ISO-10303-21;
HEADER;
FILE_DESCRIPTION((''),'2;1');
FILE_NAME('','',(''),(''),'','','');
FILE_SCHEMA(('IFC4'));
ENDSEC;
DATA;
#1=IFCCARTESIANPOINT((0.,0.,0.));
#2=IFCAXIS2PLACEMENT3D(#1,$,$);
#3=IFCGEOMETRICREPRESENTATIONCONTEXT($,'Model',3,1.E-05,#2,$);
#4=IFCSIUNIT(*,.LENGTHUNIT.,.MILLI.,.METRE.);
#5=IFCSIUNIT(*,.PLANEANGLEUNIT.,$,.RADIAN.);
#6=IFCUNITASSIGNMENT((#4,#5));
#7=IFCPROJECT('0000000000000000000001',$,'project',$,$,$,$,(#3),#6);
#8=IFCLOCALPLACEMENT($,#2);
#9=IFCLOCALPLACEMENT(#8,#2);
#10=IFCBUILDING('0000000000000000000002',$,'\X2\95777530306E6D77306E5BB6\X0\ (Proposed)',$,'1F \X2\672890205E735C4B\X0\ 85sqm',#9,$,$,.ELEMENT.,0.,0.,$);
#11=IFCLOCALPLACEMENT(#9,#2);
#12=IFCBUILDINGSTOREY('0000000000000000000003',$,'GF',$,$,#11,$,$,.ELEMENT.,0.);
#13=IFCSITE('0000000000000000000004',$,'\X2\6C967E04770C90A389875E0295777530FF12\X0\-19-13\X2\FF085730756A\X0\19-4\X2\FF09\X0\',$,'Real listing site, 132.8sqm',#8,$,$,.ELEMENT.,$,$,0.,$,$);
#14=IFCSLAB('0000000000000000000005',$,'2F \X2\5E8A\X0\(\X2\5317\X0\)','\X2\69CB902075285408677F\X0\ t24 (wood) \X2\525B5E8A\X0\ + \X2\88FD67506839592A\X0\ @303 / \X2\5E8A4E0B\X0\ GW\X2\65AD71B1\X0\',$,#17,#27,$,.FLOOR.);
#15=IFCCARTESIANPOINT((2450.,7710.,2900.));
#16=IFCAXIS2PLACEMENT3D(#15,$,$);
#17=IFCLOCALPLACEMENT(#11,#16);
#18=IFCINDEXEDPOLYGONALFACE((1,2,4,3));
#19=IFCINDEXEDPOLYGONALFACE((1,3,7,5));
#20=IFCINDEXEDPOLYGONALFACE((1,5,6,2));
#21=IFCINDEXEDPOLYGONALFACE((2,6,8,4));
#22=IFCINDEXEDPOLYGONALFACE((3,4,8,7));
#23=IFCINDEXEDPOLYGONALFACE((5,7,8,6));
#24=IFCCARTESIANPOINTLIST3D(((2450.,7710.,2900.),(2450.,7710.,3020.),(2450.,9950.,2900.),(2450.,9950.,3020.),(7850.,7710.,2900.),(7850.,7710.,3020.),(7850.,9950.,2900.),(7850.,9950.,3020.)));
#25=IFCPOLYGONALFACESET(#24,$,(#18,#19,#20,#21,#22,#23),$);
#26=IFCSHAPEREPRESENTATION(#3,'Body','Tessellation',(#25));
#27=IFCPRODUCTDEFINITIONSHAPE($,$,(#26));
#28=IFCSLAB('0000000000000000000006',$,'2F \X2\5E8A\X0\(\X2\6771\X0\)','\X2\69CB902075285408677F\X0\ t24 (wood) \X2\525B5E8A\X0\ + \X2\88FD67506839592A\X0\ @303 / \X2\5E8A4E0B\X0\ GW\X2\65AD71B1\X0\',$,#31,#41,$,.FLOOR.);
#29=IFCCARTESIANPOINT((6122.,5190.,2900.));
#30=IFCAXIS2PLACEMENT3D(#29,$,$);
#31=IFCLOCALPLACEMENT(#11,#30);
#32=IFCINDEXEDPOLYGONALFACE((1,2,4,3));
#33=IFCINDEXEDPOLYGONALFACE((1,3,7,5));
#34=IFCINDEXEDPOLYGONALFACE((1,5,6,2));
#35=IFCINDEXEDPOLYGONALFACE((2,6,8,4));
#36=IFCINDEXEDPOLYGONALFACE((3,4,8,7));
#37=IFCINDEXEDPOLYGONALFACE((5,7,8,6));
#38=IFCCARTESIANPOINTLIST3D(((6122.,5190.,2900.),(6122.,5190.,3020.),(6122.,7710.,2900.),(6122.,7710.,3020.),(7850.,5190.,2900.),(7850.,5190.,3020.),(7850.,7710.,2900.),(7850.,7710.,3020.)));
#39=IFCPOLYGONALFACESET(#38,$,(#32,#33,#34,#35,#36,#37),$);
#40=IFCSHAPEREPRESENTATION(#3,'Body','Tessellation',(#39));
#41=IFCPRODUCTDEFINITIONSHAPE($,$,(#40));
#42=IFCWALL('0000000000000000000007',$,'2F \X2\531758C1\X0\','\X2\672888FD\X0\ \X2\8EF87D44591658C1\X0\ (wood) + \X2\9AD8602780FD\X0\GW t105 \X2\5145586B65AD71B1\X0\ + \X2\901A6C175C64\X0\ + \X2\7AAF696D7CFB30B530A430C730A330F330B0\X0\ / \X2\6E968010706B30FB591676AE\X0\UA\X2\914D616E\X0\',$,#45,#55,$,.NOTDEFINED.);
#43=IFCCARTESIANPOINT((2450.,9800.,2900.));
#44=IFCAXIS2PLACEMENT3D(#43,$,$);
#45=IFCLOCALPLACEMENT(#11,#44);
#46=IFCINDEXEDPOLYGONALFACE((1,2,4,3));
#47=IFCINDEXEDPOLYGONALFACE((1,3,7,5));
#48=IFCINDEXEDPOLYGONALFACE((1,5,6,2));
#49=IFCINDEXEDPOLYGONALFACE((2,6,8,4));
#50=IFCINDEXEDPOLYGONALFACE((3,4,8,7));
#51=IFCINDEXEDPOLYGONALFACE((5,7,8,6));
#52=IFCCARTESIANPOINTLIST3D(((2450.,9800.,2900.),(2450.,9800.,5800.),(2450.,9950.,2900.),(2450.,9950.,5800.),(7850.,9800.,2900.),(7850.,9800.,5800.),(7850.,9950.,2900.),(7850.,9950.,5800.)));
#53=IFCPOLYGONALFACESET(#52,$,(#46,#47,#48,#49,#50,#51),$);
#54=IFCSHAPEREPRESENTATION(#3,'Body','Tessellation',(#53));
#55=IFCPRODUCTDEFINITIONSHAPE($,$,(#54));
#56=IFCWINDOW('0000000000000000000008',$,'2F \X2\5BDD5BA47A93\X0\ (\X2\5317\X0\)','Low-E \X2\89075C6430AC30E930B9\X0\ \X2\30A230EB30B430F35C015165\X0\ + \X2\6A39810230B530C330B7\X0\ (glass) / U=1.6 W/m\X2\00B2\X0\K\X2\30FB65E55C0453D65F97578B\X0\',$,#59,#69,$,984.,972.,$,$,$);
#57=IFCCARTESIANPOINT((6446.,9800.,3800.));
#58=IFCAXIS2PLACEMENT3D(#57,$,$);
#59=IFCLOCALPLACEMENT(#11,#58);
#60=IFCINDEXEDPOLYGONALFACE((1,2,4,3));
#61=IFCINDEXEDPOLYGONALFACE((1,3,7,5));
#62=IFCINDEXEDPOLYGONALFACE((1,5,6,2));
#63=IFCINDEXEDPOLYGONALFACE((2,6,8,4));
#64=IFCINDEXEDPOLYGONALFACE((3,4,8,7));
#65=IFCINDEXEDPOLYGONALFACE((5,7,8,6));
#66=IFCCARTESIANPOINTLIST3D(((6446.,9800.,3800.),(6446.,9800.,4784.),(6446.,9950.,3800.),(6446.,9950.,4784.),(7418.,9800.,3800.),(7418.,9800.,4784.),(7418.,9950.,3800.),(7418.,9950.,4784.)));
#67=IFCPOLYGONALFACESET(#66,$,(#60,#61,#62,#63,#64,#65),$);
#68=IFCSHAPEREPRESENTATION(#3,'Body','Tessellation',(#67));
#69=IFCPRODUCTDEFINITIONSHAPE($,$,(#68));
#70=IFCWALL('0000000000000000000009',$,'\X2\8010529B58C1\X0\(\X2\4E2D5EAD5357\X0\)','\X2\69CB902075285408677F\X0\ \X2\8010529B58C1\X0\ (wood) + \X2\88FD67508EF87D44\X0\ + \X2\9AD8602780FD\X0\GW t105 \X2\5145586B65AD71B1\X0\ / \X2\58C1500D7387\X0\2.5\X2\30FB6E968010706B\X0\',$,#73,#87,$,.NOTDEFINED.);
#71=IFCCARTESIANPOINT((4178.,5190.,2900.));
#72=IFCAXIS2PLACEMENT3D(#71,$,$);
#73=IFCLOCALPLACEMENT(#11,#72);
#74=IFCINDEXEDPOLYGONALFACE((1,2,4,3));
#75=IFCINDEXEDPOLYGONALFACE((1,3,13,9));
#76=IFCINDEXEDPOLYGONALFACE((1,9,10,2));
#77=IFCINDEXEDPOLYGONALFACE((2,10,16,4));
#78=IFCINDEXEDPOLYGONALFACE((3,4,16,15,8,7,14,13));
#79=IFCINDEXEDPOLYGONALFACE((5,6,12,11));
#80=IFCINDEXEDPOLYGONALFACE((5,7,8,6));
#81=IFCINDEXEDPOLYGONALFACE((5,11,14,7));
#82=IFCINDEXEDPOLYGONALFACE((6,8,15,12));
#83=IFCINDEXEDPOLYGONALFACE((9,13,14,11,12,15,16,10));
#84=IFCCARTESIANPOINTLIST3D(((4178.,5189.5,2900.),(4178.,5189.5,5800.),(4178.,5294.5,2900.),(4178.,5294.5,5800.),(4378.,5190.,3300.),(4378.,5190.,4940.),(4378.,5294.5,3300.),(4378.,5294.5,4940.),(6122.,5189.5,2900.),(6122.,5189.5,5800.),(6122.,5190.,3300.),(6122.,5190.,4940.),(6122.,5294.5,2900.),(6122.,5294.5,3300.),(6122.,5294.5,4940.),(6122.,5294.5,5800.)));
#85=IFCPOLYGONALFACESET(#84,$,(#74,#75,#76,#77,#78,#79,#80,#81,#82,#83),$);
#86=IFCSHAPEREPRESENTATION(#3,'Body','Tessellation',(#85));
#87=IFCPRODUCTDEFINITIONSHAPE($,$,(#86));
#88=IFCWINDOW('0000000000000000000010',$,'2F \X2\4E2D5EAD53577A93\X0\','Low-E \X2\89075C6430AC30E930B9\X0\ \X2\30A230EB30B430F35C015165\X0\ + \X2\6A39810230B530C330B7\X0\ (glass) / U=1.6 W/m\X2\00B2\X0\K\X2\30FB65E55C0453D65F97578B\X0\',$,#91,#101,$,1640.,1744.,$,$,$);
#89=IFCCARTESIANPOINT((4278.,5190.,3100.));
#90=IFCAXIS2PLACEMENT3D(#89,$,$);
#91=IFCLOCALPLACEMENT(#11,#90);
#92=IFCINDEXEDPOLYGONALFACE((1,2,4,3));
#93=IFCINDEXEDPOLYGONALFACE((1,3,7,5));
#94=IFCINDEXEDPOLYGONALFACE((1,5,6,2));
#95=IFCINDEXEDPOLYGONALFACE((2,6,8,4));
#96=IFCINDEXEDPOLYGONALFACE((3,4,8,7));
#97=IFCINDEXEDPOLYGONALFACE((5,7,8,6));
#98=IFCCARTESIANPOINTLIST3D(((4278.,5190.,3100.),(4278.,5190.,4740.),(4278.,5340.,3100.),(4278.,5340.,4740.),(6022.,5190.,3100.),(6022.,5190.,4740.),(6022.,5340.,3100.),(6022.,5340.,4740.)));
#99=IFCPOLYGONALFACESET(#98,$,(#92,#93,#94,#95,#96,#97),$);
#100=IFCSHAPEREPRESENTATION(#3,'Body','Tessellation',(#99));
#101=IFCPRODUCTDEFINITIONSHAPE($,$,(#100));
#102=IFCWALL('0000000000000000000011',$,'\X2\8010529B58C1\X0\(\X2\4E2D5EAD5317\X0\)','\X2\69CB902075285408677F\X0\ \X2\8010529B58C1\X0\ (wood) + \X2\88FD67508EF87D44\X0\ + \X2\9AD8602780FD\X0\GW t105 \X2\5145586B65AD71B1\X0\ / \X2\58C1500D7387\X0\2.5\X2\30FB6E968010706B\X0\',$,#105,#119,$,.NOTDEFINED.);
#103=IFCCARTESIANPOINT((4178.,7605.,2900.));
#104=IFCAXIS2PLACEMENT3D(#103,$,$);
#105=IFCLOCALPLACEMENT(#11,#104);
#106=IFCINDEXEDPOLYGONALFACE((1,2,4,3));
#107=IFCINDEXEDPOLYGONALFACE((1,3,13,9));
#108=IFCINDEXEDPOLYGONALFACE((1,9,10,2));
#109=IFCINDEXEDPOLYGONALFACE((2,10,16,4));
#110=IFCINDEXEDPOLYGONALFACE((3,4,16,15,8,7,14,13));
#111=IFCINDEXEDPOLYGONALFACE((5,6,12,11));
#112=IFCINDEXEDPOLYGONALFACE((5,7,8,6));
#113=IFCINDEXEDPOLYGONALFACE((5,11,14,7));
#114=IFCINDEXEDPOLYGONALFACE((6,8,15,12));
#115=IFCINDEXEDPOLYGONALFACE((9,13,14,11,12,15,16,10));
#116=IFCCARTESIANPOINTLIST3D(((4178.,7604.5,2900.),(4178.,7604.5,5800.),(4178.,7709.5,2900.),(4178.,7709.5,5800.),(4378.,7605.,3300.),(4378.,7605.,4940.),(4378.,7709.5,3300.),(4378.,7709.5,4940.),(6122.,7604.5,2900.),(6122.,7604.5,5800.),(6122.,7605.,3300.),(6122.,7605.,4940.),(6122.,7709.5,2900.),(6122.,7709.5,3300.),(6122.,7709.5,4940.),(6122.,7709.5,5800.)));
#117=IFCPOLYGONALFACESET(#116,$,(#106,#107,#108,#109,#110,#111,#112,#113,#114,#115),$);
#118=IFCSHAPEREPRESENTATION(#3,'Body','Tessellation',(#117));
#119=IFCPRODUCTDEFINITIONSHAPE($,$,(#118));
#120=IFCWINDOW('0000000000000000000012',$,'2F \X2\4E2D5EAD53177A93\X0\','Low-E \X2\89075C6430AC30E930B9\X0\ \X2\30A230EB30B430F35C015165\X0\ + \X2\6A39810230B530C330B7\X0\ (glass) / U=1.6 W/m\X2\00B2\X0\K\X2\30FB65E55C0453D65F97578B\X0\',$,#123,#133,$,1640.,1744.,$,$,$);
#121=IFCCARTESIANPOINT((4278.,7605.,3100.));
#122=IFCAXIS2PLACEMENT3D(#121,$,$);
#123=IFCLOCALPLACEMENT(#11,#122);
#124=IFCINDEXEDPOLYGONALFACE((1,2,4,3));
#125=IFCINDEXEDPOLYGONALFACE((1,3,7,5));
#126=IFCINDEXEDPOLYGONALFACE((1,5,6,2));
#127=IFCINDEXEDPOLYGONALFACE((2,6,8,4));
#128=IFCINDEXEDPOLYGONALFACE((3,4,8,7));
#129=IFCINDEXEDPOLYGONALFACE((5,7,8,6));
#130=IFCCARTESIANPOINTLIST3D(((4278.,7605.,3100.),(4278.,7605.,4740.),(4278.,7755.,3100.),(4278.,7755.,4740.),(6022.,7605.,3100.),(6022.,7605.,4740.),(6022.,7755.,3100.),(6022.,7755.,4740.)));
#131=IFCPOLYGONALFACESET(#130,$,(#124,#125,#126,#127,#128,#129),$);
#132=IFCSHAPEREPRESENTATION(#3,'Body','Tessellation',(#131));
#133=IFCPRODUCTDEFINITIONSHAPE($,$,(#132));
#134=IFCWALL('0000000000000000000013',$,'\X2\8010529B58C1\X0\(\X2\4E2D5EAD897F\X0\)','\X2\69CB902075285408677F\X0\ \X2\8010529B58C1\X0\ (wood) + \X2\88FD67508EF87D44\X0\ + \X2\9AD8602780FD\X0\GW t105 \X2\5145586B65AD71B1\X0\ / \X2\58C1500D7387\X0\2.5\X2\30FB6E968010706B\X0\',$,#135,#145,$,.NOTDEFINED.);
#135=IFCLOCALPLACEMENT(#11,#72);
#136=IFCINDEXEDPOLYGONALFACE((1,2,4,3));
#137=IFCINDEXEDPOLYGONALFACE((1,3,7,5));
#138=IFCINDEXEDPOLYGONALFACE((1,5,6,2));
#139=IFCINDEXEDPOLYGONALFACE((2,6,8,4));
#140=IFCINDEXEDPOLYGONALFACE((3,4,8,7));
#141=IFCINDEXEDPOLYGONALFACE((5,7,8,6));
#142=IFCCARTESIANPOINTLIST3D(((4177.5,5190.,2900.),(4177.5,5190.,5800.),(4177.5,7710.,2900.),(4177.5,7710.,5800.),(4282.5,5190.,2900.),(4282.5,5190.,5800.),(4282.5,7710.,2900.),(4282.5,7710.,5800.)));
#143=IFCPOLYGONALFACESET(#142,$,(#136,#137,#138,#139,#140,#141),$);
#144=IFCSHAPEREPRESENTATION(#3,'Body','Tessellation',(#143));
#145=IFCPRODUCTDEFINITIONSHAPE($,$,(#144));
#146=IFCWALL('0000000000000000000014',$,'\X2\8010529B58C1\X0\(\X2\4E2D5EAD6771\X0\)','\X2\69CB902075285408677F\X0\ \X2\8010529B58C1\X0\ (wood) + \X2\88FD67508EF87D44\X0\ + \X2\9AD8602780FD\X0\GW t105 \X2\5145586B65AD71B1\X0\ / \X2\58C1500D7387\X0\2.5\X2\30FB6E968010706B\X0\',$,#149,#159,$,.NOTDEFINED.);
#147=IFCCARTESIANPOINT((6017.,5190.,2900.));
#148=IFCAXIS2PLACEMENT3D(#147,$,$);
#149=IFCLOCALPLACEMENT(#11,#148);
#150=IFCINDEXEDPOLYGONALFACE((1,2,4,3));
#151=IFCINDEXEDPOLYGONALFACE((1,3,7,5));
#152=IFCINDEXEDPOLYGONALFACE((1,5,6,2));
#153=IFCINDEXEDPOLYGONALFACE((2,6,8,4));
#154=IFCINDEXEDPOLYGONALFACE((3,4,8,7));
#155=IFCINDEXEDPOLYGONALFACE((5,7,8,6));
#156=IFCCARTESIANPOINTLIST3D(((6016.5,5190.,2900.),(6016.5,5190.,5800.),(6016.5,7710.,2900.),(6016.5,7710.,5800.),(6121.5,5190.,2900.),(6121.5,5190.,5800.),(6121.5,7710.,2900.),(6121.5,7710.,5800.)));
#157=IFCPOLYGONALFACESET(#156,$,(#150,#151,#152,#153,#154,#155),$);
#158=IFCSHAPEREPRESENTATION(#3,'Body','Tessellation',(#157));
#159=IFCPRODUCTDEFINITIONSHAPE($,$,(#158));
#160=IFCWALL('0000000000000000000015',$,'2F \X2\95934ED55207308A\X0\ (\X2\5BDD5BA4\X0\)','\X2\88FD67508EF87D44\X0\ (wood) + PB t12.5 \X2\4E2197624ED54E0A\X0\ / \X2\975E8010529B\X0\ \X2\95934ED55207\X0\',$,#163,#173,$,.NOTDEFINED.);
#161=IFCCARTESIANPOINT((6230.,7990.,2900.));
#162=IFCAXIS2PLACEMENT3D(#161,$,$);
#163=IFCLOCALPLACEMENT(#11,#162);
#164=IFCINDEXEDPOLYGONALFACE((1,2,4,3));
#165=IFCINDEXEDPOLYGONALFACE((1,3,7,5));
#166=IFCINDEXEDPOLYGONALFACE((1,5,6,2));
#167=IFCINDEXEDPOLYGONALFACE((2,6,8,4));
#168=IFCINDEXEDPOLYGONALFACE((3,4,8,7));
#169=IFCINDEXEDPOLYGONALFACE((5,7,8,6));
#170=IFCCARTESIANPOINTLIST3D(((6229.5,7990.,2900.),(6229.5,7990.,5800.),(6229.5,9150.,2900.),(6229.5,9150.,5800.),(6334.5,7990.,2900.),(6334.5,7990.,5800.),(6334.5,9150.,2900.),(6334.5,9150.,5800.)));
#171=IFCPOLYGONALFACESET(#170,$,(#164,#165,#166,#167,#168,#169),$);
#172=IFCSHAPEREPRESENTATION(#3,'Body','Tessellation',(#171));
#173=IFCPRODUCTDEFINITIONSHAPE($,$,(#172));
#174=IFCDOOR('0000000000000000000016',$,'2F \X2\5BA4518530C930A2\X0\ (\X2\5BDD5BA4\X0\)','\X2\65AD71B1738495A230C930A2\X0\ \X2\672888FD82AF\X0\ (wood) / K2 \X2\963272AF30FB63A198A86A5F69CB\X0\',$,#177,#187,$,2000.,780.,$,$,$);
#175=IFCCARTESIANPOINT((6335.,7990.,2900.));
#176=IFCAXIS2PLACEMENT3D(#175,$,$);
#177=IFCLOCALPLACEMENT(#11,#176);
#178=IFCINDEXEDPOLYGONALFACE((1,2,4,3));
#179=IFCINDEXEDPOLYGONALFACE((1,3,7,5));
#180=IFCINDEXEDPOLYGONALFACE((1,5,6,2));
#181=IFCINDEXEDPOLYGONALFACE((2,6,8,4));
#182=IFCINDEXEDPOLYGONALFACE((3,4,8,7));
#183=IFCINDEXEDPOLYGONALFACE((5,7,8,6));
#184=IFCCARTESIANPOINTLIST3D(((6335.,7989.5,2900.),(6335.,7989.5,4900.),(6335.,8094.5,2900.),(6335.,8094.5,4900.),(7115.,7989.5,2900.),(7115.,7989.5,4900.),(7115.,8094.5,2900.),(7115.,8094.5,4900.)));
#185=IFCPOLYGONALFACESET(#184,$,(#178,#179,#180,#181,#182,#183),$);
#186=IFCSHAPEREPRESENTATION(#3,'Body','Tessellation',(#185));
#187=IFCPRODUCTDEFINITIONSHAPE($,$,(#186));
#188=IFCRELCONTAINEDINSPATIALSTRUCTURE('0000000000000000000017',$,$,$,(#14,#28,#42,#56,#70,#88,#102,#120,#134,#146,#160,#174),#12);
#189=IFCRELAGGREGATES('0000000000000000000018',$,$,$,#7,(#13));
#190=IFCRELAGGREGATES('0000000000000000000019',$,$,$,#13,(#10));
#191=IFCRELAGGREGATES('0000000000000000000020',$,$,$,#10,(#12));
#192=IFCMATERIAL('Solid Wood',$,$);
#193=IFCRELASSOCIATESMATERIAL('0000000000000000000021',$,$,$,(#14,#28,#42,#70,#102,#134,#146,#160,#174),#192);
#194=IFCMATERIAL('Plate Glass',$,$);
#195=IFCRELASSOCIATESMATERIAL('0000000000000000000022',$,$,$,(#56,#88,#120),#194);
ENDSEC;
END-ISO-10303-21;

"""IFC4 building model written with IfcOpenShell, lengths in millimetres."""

from ifc_helpers import new_model, si_unit, frame, frame_2d, origin, place, context, project, spatial, rectangle, extrude, material, element, fill, save


model = new_model("IFC4")

# Units and contexts
model_context = context("Model", 3, precision=1e-05, world=origin())
ifc_project = project(units=[si_unit("LENGTHUNIT", "METRE", prefix="MILLI"), si_unit("PLANEANGLEUNIT", "RADIAN")], contexts=[model_context])

# Site, building, storey
site_placement = place(None, origin())
site = spatial("IfcSite", under=ifc_project, at=site_placement, Name="沖縄県那覇市長田２-19-13（地番19-4）", ObjectType="Real listing site, 132.8sqm", CompositionType="ELEMENT", RefElevation=0.0)
building_placement = place(site_placement, origin())
building = spatial("IfcBuilding", under=site, at=building_placement, Name="長田の海の家 (Proposed)", ObjectType="1F 木造平屋 85sqm", CompositionType="ELEMENT", ElevationOfRefHeight=0.0, ElevationOfTerrain=0.0)
storey_placement = place(building_placement, origin())
storey = spatial("IfcBuildingStorey", under=building, at=storey_placement, Name="GF", CompositionType="ELEMENT", Elevation=0.0)

# Slabs
ifc_material_1 = material(Name="Solid Wood")
slab_1_placement = place(storey_placement, frame((2450.0, 7710.0, 2900.0)))
element("IfcSlab", 1, at=slab_1_placement, inside=storey, material=ifc_material_1, Name="2F 床(北)", Description="構造用合板 t24 (wood) 剛床 + 製材根太 @303 / 床下 GW断熱", PredefinedType="FLOOR", context=model_context, shape_type="SweptSolid", body=[
    extrude(rectangle(XDim=5400.0, YDim=2240.0, at=frame_2d((2700.0, 1120.0))), frame((2450.0, 7710.0, 2900.0)), (0.0, 0.0, 1.0), 120.0),
])
slab_2_placement = place(storey_placement, frame((6122.0, 5190.0, 2900.0)))
element("IfcSlab", 2, at=slab_2_placement, inside=storey, material=ifc_material_1, Name="2F 床(東)", Description="構造用合板 t24 (wood) 剛床 + 製材根太 @303 / 床下 GW断熱", PredefinedType="FLOOR", context=model_context, shape_type="SweptSolid", body=[
    extrude(rectangle(XDim=1728.0, YDim=2520.0, at=frame_2d((864.0, 1260.0))), frame((6122.0, 5190.0, 2900.0)), (0.0, 0.0, 1.0), 120.0),
])

# Walls, openings, windows
wall_1_placement = place(storey_placement, frame((2450.0, 9800.0, 2900.0)))
wall_1 = element("IfcWall", 3, at=wall_1_placement, inside=storey, material=ifc_material_1, Name="2F 北壁", Description="木製 軸組外壁 (wood) + 高性能GW t105 充填断熱 + 通気層 + 窯業系サイディング / 準耐火・外皮UA配慮", PredefinedType="NOTDEFINED", context=model_context, shape_type="SweptSolid", body=[
    extrude(rectangle(XDim=5400.0, YDim=150.0, at=frame_2d((2700.0, 75.0))), frame((2450.0, 9800.0, 2900.0)), (0.0, 0.0, 1.0), 2900.0),
])
opening_1_placement = place(storey_placement, frame((6446.0, 9800.0, 3800.0)))
opening_1 = element("IfcOpeningElement", 4, at=opening_1_placement, cuts=wall_1, PredefinedType="NOTDEFINED", context=model_context, shape_type="SweptSolid", body=[
    extrude(rectangle(XDim=972.0, YDim=150.0, at=frame_2d((486.0, 75.0))), frame((6446.0, 9800.0, 3800.0)), (0.0, 0.0, 1.0), 984.0),
])
ifc_material_2 = material(Name="Plate Glass")
window_1_placement = place(storey_placement, frame((6446.0, 9800.0, 3800.0)))
window_1 = element("IfcWindow", 5, at=window_1_placement, inside=storey, material=ifc_material_2, Name="2F 寝室窓 (北)", Description="Low-E 複層ガラス アルゴン封入 + 樹脂サッシ (glass) / U=1.6 W/m²K・日射取得型", OverallHeight=984.0, OverallWidth=972.0, context=model_context, shape_type="SweptSolid", body=[
    extrude(rectangle(XDim=972.0, YDim=150.0, at=frame_2d((486.0, 75.0))), frame((6446.0, 9800.0, 3800.0)), (0.0, 0.0, 1.0), 984.0),
])
fill(opening_1, window_1)
wall_2_placement = place(storey_placement, frame((4178.0, 5190.0, 2900.0)))
wall_2 = element("IfcWall", 6, at=wall_2_placement, inside=storey, material=ifc_material_1, Name="耐力壁(中庭南)", Description="構造用合板 耐力壁 (wood) + 製材軸組 + 高性能GW t105 充填断熱 / 壁倍率2.5・準耐火", PredefinedType="NOTDEFINED", context=model_context, shape_type="SweptSolid", body=[
    extrude(rectangle(XDim=1944.0, YDim=105.0, at=frame_2d((972.0, 52.0))), frame((4178.0, 5190.0, 2900.0)), (0.0, 0.0, 1.0), 2900.0),
])
opening_2_placement = place(storey_placement, frame((4278.0, 5190.0, 3100.0)))
opening_2 = element("IfcOpeningElement", 7, at=opening_2_placement, cuts=wall_2, PredefinedType="NOTDEFINED", context=model_context, shape_type="SweptSolid", body=[
    extrude(rectangle(XDim=1744.0, YDim=150.0, at=frame_2d((872.0, 75.0))), frame((4278.0, 5190.0, 3100.0)), (0.0, 0.0, 1.0), 1640.0),
])
window_2_placement = place(storey_placement, frame((4278.0, 5190.0, 3100.0)))
window_2 = element("IfcWindow", 8, at=window_2_placement, inside=storey, material=ifc_material_2, Name="2F 中庭南窓", Description="Low-E 複層ガラス アルゴン封入 + 樹脂サッシ (glass) / U=1.6 W/m²K・日射取得型", OverallHeight=1640.0, OverallWidth=1744.0, context=model_context, shape_type="SweptSolid", body=[
    extrude(rectangle(XDim=1744.0, YDim=150.0, at=frame_2d((872.0, 75.0))), frame((4278.0, 5190.0, 3100.0)), (0.0, 0.0, 1.0), 1640.0),
])
fill(opening_2, window_2)
wall_3_placement = place(storey_placement, frame((4178.0, 7605.0, 2900.0)))
wall_3 = element("IfcWall", 9, at=wall_3_placement, inside=storey, material=ifc_material_1, Name="耐力壁(中庭北)", Description="構造用合板 耐力壁 (wood) + 製材軸組 + 高性能GW t105 充填断熱 / 壁倍率2.5・準耐火", PredefinedType="NOTDEFINED", context=model_context, shape_type="SweptSolid", body=[
    extrude(rectangle(XDim=1944.0, YDim=105.0, at=frame_2d((972.0, 52.0))), frame((4178.0, 7605.0, 2900.0)), (0.0, 0.0, 1.0), 2900.0),
])
opening_3_placement = place(storey_placement, frame((4278.0, 7605.0, 3100.0)))
opening_3 = element("IfcOpeningElement", 10, at=opening_3_placement, cuts=wall_3, PredefinedType="NOTDEFINED", context=model_context, shape_type="SweptSolid", body=[
    extrude(rectangle(XDim=1744.0, YDim=150.0, at=frame_2d((872.0, 75.0))), frame((4278.0, 7605.0, 3100.0)), (0.0, 0.0, 1.0), 1640.0),
])
window_3_placement = place(storey_placement, frame((4278.0, 7605.0, 3100.0)))
window_3 = element("IfcWindow", 11, at=window_3_placement, inside=storey, material=ifc_material_2, Name="2F 中庭北窓", Description="Low-E 複層ガラス アルゴン封入 + 樹脂サッシ (glass) / U=1.6 W/m²K・日射取得型", OverallHeight=1640.0, OverallWidth=1744.0, context=model_context, shape_type="SweptSolid", body=[
    extrude(rectangle(XDim=1744.0, YDim=150.0, at=frame_2d((872.0, 75.0))), frame((4278.0, 7605.0, 3100.0)), (0.0, 0.0, 1.0), 1640.0),
])
fill(opening_3, window_3)

# Walls
wall_4_placement = place(storey_placement, frame((4178.0, 5190.0, 2900.0)))
element("IfcWall", 12, at=wall_4_placement, inside=storey, material=ifc_material_1, Name="耐力壁(中庭西)", Description="構造用合板 耐力壁 (wood) + 製材軸組 + 高性能GW t105 充填断熱 / 壁倍率2.5・準耐火", PredefinedType="NOTDEFINED", context=model_context, shape_type="SweptSolid", body=[
    extrude(rectangle(XDim=105.0, YDim=2520.0, at=frame_2d((52.0, 1260.0))), frame((4178.0, 5190.0, 2900.0)), (0.0, 0.0, 1.0), 2900.0),
])
wall_5_placement = place(storey_placement, frame((6017.0, 5190.0, 2900.0)))
element("IfcWall", 13, at=wall_5_placement, inside=storey, material=ifc_material_1, Name="耐力壁(中庭東)", Description="構造用合板 耐力壁 (wood) + 製材軸組 + 高性能GW t105 充填断熱 / 壁倍率2.5・準耐火", PredefinedType="NOTDEFINED", context=model_context, shape_type="SweptSolid", body=[
    extrude(rectangle(XDim=105.0, YDim=2520.0, at=frame_2d((52.0, 1260.0))), frame((6017.0, 5190.0, 2900.0)), (0.0, 0.0, 1.0), 2900.0),
])
wall_6_placement = place(storey_placement, frame((6230.0, 7990.0, 2900.0)))
element("IfcWall", 14, at=wall_6_placement, inside=storey, material=ifc_material_1, Name="2F 間仕切り (寝室)", Description="製材軸組 (wood) + PB t12.5 両面仕上 / 非耐力 間仕切", PredefinedType="NOTDEFINED", context=model_context, shape_type="SweptSolid", body=[
    extrude(rectangle(XDim=105.0, YDim=1160.0, at=frame_2d((52.0, 580.0))), frame((6230.0, 7990.0, 2900.0)), (0.0, 0.0, 1.0), 2900.0),
])

# Door
door_placement = place(storey_placement, frame((6335.0, 7990.0, 2900.0)))
element("IfcDoor", 15, at=door_placement, inside=storey, material=ifc_material_1, Name="2F 室内ドア (寝室)", Description="断熱玄関ドア 木製芯 (wood) / K2 防犯・採風機構", OverallHeight=2000.0, OverallWidth=780.0, context=model_context, shape_type="SweptSolid", body=[
    extrude(rectangle(XDim=780.0, YDim=105.0, at=frame_2d((390.0, 52.0))), frame((6335.0, 7990.0, 2900.0)), (0.0, 0.0, 1.0), 2000.0),
])

save(model, "model.ifc")
